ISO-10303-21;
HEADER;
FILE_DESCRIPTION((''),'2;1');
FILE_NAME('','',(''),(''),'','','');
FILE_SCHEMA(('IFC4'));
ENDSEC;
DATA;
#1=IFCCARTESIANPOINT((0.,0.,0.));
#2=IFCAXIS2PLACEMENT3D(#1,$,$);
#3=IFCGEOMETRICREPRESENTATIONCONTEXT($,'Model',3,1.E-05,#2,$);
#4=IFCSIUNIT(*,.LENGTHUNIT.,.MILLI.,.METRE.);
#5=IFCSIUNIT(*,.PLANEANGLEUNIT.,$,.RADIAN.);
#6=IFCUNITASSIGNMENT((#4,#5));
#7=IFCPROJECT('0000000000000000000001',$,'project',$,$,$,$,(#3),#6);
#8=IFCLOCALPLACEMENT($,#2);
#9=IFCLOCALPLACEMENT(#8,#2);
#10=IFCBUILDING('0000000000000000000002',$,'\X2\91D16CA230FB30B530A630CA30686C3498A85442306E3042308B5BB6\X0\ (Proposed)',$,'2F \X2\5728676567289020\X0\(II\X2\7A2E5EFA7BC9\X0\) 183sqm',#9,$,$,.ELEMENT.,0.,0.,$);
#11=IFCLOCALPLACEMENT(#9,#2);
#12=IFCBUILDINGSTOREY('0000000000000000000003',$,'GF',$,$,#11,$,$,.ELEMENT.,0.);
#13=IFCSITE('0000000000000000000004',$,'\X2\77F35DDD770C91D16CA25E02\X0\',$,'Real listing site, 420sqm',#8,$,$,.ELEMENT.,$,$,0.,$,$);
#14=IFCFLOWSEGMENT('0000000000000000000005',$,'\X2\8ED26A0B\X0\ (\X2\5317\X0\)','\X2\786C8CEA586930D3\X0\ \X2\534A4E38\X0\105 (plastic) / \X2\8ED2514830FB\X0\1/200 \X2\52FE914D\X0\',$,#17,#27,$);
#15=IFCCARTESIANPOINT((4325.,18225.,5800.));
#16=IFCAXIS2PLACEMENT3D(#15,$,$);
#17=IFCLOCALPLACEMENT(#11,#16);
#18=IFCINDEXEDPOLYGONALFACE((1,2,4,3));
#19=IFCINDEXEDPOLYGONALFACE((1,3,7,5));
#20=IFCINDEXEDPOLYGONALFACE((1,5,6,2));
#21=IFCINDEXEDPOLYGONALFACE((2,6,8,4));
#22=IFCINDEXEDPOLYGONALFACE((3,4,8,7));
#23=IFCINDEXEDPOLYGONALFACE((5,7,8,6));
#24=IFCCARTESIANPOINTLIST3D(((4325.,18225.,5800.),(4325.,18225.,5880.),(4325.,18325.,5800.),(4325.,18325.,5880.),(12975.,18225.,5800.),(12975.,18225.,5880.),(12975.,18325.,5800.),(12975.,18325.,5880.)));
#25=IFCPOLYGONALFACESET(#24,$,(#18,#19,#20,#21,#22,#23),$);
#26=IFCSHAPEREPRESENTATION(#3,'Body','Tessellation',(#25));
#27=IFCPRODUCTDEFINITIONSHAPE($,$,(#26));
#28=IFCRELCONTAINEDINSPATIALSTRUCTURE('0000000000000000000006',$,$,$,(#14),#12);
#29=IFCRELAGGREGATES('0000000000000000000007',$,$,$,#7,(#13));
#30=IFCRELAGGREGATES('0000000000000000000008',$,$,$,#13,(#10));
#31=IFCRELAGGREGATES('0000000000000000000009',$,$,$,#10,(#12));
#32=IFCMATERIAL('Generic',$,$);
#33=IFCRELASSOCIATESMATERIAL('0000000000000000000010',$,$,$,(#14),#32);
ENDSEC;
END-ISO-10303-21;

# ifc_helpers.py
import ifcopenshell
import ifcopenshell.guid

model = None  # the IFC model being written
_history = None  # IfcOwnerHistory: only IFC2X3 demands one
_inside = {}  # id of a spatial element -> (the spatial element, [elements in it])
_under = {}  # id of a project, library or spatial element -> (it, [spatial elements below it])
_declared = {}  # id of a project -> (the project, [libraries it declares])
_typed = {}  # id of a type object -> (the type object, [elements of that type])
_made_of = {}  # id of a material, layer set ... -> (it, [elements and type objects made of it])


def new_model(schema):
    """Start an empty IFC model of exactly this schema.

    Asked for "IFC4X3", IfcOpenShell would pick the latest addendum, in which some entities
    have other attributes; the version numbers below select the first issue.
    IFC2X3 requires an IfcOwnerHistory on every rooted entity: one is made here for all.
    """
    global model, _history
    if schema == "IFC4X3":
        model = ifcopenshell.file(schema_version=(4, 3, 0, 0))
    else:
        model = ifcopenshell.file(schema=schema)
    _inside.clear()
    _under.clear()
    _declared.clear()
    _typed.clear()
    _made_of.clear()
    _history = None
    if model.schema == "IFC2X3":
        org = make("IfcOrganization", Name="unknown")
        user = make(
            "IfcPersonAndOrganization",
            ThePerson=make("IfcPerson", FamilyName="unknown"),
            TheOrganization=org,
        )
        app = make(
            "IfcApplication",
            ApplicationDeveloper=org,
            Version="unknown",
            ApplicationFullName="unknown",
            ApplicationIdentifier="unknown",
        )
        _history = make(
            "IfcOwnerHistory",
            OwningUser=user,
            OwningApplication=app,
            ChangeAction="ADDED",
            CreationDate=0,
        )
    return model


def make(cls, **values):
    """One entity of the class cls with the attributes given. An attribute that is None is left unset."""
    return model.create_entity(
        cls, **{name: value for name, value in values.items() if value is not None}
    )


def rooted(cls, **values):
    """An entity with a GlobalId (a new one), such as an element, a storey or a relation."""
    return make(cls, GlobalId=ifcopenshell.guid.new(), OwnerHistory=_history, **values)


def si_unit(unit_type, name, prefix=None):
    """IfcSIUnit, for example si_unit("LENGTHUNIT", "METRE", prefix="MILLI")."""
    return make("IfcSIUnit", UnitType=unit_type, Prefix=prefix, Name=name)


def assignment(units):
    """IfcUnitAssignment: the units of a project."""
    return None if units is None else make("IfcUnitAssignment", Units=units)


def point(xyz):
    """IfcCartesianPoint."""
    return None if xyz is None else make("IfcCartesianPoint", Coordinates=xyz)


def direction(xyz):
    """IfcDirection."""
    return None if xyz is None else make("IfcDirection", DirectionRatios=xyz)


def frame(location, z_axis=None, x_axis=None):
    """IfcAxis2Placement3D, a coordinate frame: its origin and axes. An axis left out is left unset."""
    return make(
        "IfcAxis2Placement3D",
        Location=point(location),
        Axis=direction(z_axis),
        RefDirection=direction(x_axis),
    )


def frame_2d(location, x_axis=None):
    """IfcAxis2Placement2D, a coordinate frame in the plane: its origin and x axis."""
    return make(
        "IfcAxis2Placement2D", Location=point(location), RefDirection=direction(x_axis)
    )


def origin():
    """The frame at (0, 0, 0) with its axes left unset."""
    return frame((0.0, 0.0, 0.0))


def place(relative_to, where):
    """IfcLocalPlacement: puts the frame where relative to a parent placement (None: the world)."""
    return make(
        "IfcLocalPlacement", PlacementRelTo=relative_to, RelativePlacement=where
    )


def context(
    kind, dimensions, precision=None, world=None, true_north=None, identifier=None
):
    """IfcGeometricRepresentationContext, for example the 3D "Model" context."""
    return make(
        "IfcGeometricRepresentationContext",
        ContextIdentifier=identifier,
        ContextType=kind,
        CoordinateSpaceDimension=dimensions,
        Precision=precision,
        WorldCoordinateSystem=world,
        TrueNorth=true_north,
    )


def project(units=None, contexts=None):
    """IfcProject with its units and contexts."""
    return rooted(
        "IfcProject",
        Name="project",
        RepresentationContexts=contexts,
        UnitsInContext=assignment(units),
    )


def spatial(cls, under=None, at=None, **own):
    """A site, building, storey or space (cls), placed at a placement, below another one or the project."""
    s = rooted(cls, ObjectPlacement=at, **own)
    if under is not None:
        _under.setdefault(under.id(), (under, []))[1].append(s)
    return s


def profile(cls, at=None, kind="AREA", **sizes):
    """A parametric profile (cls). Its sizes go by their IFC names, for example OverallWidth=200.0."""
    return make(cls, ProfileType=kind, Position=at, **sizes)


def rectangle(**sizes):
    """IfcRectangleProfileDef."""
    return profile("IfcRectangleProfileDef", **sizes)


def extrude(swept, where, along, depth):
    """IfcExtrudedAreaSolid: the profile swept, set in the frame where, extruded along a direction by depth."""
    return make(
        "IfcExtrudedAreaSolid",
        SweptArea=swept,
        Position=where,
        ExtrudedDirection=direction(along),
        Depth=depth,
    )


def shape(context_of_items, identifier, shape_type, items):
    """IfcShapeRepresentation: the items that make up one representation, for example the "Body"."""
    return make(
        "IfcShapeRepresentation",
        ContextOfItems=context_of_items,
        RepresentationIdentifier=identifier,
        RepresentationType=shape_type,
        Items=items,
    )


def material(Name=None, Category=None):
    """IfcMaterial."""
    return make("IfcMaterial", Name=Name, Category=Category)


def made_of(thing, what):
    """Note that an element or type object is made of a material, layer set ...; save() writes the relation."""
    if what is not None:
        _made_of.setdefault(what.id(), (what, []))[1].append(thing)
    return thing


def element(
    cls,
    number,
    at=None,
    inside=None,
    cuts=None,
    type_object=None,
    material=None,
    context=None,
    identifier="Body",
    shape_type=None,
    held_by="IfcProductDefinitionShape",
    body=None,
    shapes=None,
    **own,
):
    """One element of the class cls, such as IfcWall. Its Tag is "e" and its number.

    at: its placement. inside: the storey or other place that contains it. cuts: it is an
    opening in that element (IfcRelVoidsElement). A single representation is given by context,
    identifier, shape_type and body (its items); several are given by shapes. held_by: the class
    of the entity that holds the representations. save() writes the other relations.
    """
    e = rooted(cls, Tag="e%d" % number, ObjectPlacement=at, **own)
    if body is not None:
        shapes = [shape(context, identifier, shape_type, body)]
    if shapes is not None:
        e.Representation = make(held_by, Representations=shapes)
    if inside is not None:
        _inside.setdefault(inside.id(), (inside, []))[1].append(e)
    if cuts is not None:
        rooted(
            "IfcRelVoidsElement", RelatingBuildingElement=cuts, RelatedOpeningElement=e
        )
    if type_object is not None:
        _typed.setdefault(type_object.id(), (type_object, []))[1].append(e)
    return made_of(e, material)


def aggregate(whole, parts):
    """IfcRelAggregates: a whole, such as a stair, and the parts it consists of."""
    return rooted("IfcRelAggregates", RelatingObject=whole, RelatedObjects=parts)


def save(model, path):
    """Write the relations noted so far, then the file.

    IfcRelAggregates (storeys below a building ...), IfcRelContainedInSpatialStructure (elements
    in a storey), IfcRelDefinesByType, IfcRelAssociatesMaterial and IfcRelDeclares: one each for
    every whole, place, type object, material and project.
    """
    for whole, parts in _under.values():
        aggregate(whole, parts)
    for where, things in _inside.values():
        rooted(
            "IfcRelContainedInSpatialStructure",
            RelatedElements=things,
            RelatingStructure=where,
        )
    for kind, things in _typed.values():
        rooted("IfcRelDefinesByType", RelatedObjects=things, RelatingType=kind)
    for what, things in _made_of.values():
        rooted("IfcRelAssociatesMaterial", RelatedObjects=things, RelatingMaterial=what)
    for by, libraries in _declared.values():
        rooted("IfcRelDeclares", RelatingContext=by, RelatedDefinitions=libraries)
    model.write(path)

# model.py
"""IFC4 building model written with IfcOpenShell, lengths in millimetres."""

from ifc_helpers import new_model, si_unit, frame, frame_2d, origin, place, context, project, spatial, rectangle, extrude, material, element, save


model = new_model("IFC4")

# Units and contexts
model_context = context("Model", 3, precision=1e-05, world=origin())
ifc_project = project(units=[si_unit("LENGTHUNIT", "METRE", prefix="MILLI"), si_unit("PLANEANGLEUNIT", "RADIAN")], contexts=[model_context])

# Site, building, storey
site_placement = place(None, origin())
site = spatial("IfcSite", under=ifc_project, at=site_placement, Name="石川県金沢市", ObjectType="Real listing site, 420sqm", CompositionType="ELEMENT", RefElevation=0.0)
building_placement = place(site_placement, origin())
building = spatial("IfcBuilding", under=site, at=building_placement, Name="金沢・サウナと水風呂のある家 (Proposed)", ObjectType="2F 在来木造(II種建築) 183sqm", CompositionType="ELEMENT", ElevationOfRefHeight=0.0, ElevationOfTerrain=0.0)
storey_placement = place(building_placement, origin())
storey = spatial("IfcBuildingStorey", under=building, at=storey_placement, Name="GF", CompositionType="ELEMENT", Elevation=0.0)

# Shared definitions
ifc_material_1 = material(Name="Generic")

# Flow segment
flow_segment_placement = place(storey_placement, frame((4325.0, 18225.0, 5800.0)))
element("IfcFlowSegment", 1, at=flow_segment_placement, inside=storey, material=ifc_material_1, Name="軒樋 (北)", Description="硬質塩ビ 半丸105 (plastic) / 軒先・1/200 勾配", context=model_context, shape_type="SweptSolid", body=[
    extrude(rectangle(XDim=8650.0, YDim=100.0, at=frame_2d((4325.0, 50.0))), frame((4325.0, 18225.0, 5800.0)), (0.0, 0.0, 1.0), 80.0),
])

save(model, "model.ifc")
